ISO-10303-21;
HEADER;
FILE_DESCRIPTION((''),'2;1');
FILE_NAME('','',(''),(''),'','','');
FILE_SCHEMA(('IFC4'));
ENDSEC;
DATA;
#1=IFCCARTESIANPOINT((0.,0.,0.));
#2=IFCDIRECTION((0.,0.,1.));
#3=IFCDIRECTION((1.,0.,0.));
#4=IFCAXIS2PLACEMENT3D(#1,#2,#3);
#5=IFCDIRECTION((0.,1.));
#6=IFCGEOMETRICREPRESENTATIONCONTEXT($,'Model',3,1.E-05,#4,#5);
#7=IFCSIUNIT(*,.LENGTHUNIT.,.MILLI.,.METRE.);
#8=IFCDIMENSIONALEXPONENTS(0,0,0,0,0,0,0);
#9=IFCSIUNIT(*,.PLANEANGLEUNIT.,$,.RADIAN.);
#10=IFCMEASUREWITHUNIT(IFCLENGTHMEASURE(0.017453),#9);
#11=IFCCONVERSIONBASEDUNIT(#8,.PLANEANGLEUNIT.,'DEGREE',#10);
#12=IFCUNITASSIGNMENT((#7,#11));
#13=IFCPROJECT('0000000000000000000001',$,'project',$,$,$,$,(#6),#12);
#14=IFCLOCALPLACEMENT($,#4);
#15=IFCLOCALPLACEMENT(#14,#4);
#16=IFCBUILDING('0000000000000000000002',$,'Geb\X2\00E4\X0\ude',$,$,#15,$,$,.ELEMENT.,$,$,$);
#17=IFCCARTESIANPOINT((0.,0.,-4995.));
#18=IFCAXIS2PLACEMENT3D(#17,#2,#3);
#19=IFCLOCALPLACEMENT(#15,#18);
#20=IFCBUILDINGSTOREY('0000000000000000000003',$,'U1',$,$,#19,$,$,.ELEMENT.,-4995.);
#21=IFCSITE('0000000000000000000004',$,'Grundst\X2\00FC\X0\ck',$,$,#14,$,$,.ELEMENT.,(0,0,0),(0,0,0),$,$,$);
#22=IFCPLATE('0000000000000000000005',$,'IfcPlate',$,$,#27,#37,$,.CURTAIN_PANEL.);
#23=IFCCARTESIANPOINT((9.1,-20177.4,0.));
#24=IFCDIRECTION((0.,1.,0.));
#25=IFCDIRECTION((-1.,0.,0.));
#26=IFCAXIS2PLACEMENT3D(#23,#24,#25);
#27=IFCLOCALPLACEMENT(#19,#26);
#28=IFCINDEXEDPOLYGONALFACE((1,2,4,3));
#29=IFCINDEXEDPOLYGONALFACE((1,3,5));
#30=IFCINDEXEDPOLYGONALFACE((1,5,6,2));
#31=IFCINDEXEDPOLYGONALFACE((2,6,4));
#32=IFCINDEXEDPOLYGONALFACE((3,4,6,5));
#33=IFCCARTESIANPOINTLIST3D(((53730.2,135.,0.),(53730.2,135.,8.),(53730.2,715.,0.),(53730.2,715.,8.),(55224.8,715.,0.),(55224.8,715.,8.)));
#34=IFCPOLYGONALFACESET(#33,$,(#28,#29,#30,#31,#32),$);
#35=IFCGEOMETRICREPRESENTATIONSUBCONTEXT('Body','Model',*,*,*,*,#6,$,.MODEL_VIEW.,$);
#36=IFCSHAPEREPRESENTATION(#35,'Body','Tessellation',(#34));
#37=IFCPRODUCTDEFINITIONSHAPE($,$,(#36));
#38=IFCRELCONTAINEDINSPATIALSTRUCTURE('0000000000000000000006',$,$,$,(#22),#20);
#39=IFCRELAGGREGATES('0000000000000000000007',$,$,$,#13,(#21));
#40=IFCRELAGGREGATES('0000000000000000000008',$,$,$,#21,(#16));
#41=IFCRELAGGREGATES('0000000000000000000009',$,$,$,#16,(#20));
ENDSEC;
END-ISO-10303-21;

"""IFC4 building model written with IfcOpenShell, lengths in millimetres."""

from ifc_helpers import new_model, entity, si_unit, converted_unit, direction, frame, origin_with_axes, place, context, subcontext, project, spatial, line, indexed_curve, outline, extrude, element, save


model = new_model("IFC4")

# Units and contexts
model_context = context("Model", 3, precision=1e-05, world=origin_with_axes(), true_north=direction((0.0, 1.0)))
body_context = subcontext(model_context, "Body", "Model", "MODEL_VIEW")
ifc_project = project(units=[si_unit("LENGTHUNIT", "METRE", prefix="MILLI"), converted_unit("PLANEANGLEUNIT", "DEGREE", entity("IfcLengthMeasure", 0.017453), si_unit("PLANEANGLEUNIT", "RADIAN"), dimensions=[0, 0, 0, 0, 0, 0, 0])], contexts=[model_context])

# Site, building, storey
site_placement = place(None, origin_with_axes())
site = spatial("IfcSite", under=ifc_project, at=site_placement, Name="Grundstück", CompositionType="ELEMENT", RefLatitude=(0, 0, 0), RefLongitude=(0, 0, 0))
building_placement = place(site_placement, origin_with_axes())
building = spatial("IfcBuilding", under=site, at=building_placement, Name="Gebäude", CompositionType="ELEMENT")
storey_placement = place(building_placement, frame((0.0, 0.0, -4995.0), z_axis=(0.0, 0.0, 1.0), x_axis=(1.0, 0.0, 0.0)))
storey = spatial("IfcBuildingStorey", under=building, at=storey_placement, Name="U1", CompositionType="ELEMENT", Elevation=-4995.0)

# Plate
plate_1_placement = place(storey_placement, frame((9.1, -20177.4, 0.0), z_axis=(0.0, 1.0, 0.0), x_axis=(-1.0, 0.0, 0.0)))
element("IfcPlate", 1, at=plate_1_placement, inside=storey, Name="IfcPlate", PredefinedType="CURTAIN_PANEL", context=body_context, shape_type="SweptSolid", body=[
    extrude(outline(indexed_curve([(53730.2, 715.0), (53730.2, 135.0), (55224.8, 715.0)], segments=[line(1, 2), line(2, 3), line(3, 1)])), origin_with_axes(), (0.0, 0.0, 1.0), 8.0),
])

save(model, "model.ifc")
